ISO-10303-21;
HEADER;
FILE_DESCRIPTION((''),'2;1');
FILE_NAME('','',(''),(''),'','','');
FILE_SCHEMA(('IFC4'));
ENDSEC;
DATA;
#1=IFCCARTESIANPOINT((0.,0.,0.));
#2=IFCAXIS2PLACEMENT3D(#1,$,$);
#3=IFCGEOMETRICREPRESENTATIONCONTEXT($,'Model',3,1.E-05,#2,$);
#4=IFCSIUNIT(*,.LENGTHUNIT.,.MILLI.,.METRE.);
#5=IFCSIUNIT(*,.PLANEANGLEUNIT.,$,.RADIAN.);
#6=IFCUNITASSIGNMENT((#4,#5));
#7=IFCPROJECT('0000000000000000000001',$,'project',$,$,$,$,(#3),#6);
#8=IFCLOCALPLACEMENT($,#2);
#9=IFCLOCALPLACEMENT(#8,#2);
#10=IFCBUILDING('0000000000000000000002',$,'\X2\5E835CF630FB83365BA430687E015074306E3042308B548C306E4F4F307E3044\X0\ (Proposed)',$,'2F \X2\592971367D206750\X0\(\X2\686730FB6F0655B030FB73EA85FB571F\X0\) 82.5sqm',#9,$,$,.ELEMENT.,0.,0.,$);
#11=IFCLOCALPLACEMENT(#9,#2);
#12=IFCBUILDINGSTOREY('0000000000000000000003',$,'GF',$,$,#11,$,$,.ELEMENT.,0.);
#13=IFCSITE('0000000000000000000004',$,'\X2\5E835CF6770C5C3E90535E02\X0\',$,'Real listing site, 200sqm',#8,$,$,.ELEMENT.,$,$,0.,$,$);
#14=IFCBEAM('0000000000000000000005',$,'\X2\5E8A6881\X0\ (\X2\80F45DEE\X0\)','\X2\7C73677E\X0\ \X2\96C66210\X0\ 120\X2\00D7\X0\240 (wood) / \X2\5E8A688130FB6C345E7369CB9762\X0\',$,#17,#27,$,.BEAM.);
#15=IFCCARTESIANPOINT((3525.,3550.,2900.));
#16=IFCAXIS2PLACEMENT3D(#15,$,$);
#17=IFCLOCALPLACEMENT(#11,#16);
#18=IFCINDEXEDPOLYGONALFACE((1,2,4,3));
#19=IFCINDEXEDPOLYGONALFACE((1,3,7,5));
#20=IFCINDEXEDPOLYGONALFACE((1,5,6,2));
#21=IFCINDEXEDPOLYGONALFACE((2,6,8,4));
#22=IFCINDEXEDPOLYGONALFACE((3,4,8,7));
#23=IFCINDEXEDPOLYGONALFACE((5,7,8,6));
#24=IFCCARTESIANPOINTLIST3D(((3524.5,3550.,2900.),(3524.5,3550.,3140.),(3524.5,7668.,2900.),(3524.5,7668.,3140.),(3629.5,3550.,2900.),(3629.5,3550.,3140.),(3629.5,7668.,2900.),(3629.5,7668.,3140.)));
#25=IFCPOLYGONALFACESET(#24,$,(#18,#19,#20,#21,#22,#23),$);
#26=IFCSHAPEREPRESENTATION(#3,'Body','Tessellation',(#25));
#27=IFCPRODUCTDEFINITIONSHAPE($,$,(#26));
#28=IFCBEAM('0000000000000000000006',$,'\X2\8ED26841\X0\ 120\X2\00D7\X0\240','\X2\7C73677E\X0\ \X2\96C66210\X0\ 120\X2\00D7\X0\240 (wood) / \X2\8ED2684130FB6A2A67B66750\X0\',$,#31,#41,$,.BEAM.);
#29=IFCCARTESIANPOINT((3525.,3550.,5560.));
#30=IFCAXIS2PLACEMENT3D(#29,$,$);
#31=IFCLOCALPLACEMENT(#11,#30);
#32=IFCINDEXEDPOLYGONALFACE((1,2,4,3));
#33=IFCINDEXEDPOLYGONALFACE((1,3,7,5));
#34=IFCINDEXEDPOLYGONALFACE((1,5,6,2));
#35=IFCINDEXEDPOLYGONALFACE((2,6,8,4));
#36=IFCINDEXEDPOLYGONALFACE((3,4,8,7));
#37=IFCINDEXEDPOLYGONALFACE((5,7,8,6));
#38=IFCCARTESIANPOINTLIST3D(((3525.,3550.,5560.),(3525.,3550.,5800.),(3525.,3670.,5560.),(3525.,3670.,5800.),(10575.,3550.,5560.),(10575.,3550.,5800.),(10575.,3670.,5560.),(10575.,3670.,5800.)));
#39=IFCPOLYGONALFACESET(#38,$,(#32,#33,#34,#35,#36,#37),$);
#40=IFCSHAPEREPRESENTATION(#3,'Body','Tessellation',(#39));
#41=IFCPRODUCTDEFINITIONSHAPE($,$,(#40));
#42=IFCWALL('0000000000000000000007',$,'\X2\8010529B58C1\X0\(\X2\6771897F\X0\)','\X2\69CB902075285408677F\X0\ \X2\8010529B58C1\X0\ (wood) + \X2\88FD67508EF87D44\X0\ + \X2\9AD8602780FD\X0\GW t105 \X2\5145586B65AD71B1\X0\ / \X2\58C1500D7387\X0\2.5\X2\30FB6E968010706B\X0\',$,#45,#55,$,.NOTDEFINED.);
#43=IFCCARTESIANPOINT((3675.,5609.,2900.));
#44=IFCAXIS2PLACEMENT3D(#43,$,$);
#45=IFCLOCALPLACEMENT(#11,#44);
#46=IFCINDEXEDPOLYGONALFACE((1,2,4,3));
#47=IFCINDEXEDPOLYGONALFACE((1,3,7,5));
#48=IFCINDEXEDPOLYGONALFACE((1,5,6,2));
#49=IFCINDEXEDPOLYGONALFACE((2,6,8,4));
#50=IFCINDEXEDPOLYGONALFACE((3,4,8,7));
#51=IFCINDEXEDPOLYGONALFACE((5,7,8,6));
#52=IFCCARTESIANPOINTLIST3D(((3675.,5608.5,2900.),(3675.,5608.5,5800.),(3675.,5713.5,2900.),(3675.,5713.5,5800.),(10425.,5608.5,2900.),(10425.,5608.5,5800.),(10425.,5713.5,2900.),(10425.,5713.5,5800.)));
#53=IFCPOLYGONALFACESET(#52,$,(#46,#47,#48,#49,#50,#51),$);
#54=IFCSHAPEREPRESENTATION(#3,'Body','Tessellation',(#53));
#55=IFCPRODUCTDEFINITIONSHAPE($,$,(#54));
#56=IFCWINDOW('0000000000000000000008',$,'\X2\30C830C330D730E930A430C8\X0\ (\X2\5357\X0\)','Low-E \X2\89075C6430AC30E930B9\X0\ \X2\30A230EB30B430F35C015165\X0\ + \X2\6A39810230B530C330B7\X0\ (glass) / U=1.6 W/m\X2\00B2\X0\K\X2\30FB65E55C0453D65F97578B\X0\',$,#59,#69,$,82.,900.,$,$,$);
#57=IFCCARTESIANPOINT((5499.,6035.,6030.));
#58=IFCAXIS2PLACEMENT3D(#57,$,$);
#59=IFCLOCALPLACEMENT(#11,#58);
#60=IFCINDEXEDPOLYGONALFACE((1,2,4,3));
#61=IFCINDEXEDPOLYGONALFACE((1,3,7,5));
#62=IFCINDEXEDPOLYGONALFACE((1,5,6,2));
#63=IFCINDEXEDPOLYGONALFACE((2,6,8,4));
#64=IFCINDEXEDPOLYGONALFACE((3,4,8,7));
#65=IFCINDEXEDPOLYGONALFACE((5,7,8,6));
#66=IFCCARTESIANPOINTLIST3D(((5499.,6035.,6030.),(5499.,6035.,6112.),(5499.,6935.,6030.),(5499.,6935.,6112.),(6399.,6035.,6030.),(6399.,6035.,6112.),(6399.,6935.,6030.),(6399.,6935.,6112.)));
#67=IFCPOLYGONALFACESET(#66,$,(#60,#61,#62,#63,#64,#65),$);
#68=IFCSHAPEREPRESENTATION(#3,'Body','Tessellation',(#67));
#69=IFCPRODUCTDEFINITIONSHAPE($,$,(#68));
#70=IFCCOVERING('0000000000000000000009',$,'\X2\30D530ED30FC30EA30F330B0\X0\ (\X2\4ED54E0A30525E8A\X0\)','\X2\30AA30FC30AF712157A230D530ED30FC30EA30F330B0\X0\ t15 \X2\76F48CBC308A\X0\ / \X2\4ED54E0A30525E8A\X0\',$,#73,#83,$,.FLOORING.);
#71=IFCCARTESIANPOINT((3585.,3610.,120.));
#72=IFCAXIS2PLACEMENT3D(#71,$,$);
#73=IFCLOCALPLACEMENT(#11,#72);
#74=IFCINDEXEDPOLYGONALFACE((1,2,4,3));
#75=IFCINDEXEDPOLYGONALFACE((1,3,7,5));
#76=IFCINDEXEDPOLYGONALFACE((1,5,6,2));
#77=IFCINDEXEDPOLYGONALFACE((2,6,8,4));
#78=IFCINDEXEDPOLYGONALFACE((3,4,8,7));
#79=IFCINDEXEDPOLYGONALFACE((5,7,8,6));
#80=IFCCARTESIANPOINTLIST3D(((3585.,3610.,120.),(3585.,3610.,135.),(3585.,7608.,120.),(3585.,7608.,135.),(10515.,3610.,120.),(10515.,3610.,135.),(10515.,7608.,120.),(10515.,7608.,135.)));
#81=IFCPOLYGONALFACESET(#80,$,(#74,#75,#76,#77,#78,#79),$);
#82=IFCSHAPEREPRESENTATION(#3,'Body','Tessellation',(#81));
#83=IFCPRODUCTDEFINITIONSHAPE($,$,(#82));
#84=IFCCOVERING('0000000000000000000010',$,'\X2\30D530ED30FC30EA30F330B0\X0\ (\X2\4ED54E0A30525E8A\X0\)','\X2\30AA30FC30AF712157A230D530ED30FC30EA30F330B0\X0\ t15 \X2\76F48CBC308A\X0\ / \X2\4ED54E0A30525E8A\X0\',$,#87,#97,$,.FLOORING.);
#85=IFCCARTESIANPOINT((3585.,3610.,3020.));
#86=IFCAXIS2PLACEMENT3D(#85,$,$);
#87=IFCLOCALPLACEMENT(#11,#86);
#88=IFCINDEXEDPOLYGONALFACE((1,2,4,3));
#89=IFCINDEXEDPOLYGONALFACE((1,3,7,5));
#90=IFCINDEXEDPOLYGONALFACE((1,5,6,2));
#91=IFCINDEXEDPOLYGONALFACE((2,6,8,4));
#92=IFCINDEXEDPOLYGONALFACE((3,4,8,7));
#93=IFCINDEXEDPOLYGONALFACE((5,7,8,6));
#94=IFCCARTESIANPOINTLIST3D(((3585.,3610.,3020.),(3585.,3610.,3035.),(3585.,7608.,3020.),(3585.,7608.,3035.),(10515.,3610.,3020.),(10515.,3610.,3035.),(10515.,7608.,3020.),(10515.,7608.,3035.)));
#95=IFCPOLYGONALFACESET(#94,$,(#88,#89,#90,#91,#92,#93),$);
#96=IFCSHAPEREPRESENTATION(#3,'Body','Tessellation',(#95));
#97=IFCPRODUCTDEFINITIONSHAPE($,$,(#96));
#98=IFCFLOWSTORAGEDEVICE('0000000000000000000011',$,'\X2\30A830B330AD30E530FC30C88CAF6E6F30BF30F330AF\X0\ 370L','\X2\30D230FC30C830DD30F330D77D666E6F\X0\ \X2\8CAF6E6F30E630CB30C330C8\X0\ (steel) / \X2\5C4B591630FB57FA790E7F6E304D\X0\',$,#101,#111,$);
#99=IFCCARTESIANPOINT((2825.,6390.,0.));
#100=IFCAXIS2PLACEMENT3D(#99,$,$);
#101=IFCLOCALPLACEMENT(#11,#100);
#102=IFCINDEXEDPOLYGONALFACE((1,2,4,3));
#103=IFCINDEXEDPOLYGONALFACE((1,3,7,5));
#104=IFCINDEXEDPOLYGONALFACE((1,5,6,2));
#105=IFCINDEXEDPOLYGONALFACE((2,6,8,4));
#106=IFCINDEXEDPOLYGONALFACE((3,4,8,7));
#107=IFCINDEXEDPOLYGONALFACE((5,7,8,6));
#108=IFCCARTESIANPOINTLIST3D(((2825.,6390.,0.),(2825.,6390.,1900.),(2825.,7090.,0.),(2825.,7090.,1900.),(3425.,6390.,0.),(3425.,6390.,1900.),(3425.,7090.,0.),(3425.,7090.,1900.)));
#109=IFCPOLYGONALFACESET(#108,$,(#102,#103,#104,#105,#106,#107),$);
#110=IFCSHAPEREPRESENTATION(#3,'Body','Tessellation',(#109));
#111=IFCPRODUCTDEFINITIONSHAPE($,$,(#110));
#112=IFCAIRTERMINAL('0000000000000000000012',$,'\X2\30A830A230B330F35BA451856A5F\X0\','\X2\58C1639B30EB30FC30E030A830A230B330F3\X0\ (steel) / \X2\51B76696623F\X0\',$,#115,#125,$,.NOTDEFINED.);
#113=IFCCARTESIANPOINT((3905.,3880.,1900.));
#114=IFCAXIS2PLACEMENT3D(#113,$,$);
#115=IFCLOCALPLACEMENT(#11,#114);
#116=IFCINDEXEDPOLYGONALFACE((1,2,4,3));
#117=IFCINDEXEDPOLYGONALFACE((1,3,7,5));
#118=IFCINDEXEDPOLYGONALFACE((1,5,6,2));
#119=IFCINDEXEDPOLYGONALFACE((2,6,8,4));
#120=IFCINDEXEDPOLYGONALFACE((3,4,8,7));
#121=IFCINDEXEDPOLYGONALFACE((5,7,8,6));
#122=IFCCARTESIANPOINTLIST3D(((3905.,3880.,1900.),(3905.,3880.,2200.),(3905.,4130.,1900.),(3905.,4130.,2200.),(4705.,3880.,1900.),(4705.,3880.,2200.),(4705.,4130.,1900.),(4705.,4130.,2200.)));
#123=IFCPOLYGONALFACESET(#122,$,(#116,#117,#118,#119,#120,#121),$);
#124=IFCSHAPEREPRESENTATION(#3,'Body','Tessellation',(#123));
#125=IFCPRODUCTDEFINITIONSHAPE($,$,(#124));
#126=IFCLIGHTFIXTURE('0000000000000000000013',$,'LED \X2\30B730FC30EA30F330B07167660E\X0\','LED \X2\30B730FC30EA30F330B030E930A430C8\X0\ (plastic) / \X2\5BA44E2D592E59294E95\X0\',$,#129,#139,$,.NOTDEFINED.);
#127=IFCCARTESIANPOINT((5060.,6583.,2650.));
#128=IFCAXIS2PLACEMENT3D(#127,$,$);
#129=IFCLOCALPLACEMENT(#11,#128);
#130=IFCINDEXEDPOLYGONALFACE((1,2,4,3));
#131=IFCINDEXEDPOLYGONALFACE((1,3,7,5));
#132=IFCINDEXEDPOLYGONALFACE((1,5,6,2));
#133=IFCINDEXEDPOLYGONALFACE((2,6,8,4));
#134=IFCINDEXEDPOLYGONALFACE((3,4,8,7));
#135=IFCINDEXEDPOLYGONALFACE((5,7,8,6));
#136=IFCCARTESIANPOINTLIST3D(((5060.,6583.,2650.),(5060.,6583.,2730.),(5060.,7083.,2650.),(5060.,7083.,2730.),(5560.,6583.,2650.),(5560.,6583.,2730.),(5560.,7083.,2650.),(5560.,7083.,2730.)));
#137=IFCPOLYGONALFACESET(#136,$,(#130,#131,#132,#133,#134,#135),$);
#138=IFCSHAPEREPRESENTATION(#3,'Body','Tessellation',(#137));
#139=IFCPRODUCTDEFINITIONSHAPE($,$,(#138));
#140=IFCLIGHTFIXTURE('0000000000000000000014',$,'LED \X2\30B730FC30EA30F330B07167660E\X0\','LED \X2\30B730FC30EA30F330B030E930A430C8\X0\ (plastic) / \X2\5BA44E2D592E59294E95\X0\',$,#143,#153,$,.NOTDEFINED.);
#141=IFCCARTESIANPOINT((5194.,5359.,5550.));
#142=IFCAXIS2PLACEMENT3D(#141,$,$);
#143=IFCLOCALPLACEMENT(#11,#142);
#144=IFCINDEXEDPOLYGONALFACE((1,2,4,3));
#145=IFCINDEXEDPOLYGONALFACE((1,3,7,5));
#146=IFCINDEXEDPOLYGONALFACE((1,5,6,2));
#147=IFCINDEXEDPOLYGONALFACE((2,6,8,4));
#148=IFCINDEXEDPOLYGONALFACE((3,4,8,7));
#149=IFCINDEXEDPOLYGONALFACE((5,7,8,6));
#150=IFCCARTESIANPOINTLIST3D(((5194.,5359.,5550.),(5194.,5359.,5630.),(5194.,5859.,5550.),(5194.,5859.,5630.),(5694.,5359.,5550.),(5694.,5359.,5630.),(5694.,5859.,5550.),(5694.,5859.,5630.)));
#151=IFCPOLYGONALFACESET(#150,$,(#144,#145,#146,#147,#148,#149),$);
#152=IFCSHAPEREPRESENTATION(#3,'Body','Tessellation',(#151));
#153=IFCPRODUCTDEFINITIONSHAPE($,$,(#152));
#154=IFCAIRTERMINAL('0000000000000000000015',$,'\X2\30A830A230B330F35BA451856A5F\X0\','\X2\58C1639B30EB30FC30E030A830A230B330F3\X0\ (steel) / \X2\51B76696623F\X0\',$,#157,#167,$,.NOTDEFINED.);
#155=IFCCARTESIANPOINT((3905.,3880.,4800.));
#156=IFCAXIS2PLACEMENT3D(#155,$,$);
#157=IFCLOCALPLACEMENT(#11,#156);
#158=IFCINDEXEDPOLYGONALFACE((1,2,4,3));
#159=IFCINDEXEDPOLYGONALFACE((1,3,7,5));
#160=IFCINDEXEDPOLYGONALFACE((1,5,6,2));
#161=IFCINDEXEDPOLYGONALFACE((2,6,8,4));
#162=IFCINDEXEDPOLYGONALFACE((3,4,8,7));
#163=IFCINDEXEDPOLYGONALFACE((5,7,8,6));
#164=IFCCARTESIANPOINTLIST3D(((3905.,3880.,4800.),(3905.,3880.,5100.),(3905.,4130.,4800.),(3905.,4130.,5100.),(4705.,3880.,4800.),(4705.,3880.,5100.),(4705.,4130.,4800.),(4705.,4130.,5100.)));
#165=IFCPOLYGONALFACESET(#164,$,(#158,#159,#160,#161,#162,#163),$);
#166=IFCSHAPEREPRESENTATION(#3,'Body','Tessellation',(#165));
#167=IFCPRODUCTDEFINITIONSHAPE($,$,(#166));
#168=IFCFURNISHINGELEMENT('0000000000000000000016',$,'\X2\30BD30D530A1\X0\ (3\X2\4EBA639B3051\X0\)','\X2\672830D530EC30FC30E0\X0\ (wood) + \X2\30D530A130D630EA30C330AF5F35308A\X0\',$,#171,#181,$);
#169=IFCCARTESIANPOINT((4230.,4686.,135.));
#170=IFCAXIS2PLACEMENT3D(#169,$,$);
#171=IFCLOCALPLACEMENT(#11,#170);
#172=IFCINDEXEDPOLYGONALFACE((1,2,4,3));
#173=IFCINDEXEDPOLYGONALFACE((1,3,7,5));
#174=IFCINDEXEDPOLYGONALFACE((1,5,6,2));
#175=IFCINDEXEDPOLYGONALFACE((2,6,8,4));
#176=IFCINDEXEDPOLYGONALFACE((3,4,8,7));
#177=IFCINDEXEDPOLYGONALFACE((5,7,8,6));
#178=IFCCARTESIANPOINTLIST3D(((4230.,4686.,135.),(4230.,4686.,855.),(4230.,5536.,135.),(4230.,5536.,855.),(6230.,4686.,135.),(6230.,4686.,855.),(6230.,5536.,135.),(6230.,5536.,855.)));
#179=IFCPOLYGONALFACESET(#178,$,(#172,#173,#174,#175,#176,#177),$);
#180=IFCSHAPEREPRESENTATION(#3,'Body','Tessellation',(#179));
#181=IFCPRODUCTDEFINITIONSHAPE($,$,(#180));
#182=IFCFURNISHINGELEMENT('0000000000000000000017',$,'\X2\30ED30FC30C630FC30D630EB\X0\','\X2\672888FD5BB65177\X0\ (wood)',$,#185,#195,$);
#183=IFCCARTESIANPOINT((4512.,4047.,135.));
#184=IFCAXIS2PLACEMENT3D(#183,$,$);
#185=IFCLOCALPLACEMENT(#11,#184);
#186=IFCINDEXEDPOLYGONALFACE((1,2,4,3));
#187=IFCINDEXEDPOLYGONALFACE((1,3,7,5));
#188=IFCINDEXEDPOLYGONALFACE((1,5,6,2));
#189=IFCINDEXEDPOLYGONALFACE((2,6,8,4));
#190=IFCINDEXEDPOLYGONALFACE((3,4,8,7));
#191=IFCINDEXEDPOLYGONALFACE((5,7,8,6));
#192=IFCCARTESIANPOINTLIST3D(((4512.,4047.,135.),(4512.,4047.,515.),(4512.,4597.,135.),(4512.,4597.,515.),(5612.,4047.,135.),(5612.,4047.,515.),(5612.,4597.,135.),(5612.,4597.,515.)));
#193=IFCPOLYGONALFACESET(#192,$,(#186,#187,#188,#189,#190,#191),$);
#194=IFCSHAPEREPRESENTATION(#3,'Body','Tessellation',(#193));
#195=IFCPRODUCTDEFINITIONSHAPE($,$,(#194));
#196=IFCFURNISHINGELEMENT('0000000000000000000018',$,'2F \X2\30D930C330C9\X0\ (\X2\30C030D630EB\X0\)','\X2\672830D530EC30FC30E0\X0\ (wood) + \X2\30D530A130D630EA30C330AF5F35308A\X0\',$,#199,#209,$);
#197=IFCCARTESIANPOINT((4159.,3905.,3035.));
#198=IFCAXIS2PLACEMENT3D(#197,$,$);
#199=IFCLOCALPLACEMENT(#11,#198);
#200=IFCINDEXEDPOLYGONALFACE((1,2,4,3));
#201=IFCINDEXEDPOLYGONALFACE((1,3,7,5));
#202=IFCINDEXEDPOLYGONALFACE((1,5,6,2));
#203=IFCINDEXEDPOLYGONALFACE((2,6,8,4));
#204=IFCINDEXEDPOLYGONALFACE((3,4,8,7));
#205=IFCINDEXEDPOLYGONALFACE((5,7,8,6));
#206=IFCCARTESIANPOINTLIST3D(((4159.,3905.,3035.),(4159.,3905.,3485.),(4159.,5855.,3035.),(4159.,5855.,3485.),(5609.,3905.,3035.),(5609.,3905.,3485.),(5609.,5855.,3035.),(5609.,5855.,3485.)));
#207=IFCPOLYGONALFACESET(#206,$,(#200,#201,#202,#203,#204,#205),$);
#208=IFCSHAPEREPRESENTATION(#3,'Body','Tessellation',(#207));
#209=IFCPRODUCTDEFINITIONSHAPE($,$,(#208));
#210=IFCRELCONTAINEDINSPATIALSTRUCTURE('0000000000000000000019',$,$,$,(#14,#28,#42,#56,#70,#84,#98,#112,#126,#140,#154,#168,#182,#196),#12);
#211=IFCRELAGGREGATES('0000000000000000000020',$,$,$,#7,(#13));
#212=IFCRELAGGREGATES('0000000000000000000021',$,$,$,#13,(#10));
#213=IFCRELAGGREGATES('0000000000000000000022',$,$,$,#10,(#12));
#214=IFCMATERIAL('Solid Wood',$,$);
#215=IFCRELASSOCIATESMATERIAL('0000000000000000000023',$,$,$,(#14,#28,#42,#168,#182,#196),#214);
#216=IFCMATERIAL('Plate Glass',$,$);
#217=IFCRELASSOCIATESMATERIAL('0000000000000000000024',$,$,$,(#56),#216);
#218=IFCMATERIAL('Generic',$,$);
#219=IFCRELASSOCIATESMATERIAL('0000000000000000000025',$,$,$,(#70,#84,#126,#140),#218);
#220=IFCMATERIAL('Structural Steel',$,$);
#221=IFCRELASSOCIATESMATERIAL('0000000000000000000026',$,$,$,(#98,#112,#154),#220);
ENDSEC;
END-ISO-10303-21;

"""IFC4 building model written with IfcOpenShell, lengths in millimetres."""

from ifc_helpers import new_model, si_unit, frame, frame_2d, origin, place, context, project, spatial, rectangle, extrude, material, element, save


model = new_model("IFC4")

# Units and contexts
model_context = context("Model", 3, precision=1e-05, world=origin())
ifc_project = project(units=[si_unit("LENGTHUNIT", "METRE", prefix="MILLI"), si_unit("PLANEANGLEUNIT", "RADIAN")], contexts=[model_context])

# Site, building, storey
site_placement = place(None, origin())
site = spatial("IfcSite", under=ifc_project, at=site_placement, Name="広島県尾道市", ObjectType="Real listing site, 200sqm", CompositionType="ELEMENT", RefElevation=0.0)
building_placement = place(site_placement, origin())
building = spatial("IfcBuilding", under=site, at=building_placement, Name="広島・茶室と縁側のある和の住まい (Proposed)", ObjectType="2F 天然素材(桧・漆喰・珪藻土) 82.5sqm", CompositionType="ELEMENT", ElevationOfRefHeight=0.0, ElevationOfTerrain=0.0)
storey_placement = place(building_placement, origin())
storey = spatial("IfcBuildingStorey", under=building, at=storey_placement, Name="GF", CompositionType="ELEMENT", Elevation=0.0)

# Shared definitions
ifc_material_1 = material(Name="Solid Wood")

# Beams
beam_1_placement = place(storey_placement, frame((3525.0, 3550.0, 2900.0)))
element("IfcBeam", 1, at=beam_1_placement, inside=storey, material=ifc_material_1, Name="床梁 (胴差)", Description="米松 集成 120×240 (wood) / 床梁・水平構面", PredefinedType="BEAM", context=model_context, shape_type="SweptSolid", body=[
    extrude(rectangle(XDim=105.0, YDim=4118.0, at=frame_2d((52.0, 2059.0))), frame((3525.0, 3550.0, 2900.0)), (0.0, 0.0, 1.0), 240.0),
])
beam_2_placement = place(storey_placement, frame((3525.0, 3550.0, 5560.0)))
element("IfcBeam", 2, at=beam_2_placement, inside=storey, material=ifc_material_1, Name="軒桁 120×240", Description="米松 集成 120×240 (wood) / 軒桁・横架材", PredefinedType="BEAM", context=model_context, shape_type="SweptSolid", body=[
    extrude(rectangle(XDim=7050.0, YDim=120.0, at=frame_2d((3525.0, 60.0))), frame((3525.0, 3550.0, 5560.0)), (0.0, 0.0, 1.0), 240.0),
])

# Wall
wall_1_placement = place(storey_placement, frame((3675.0, 5609.0, 2900.0)))
element("IfcWall", 3, at=wall_1_placement, inside=storey, material=ifc_material_1, Name="耐力壁(東西)", Description="構造用合板 耐力壁 (wood) + 製材軸組 + 高性能GW t105 充填断熱 / 壁倍率2.5・準耐火", PredefinedType="NOTDEFINED", context=model_context, shape_type="SweptSolid", body=[
    extrude(rectangle(XDim=6750.0, YDim=105.0, at=frame_2d((3375.0, 52.0))), frame((3675.0, 5609.0, 2900.0)), (0.0, 0.0, 1.0), 2900.0),
])

# Window
ifc_material_2 = material(Name="Plate Glass")
window_placement = place(storey_placement, frame((5499.0, 6035.0, 6030.0)))
element("IfcWindow", 4, at=window_placement, inside=storey, material=ifc_material_2, Name="トップライト (南)", Description="Low-E 複層ガラス アルゴン封入 + 樹脂サッシ (glass) / U=1.6 W/m²K・日射取得型", OverallHeight=82.0, OverallWidth=900.0, context=model_context, shape_type="SweptSolid", body=[
    extrude(rectangle(XDim=900.0, YDim=900.0, at=frame_2d((450.0, 450.0))), frame((5499.0, 6035.0, 6030.0)), (0.0, 0.0, 1.0), 82.0),
])

# Coverings
ifc_material_3 = material(Name="Generic")
covering_1_placement = place(storey_placement, frame((3585.0, 3610.0, 120.0)))
element("IfcCovering", 5, at=covering_1_placement, inside=storey, material=ifc_material_3, Name="フローリング (仕上げ床)", Description="オーク無垢フローリング t15 直貼り / 仕上げ床", PredefinedType="FLOORING", context=model_context, shape_type="SweptSolid", body=[
    extrude(rectangle(XDim=6930.0, YDim=3998.0, at=frame_2d((3465.0, 1999.0))), frame((3585.0, 3610.0, 120.0)), (0.0, 0.0, 1.0), 15.0),
])
covering_2_placement = place(storey_placement, frame((3585.0, 3610.0, 3020.0)))
element("IfcCovering", 6, at=covering_2_placement, inside=storey, material=ifc_material_3, Name="フローリング (仕上げ床)", Description="オーク無垢フローリング t15 直貼り / 仕上げ床", PredefinedType="FLOORING", context=model_context, shape_type="SweptSolid", body=[
    extrude(rectangle(XDim=6930.0, YDim=3998.0, at=frame_2d((3465.0, 1999.0))), frame((3585.0, 3610.0, 3020.0)), (0.0, 0.0, 1.0), 15.0),
])

# Flow storage device
ifc_material_4 = material(Name="Structural Steel")
flow_storage_device_placement = place(storey_placement, frame((2825.0, 6390.0, 0.0)))
element("IfcFlowStorageDevice", 7, at=flow_storage_device_placement, inside=storey, material=ifc_material_4, Name="エコキュート貯湯タンク 370L", Description="ヒートポンプ給湯 貯湯ユニット (steel) / 屋外・基礎置き", context=model_context, shape_type="SweptSolid", body=[
    extrude(rectangle(XDim=600.0, YDim=700.0, at=frame_2d((300.0, 350.0))), frame((2825.0, 6390.0, 0.0)), (0.0, 0.0, 1.0), 1900.0),
])

# Air terminal
air_terminal_1_placement = place(storey_placement, frame((3905.0, 3880.0, 1900.0)))
element("IfcAirTerminal", 8, at=air_terminal_1_placement, inside=storey, material=ifc_material_4, Name="エアコン室内機", Description="壁掛ルームエアコン (steel) / 冷暖房", PredefinedType="NOTDEFINED", context=model_context, shape_type="SweptSolid", body=[
    extrude(rectangle(XDim=800.0, YDim=250.0, at=frame_2d((400.0, 125.0))), frame((3905.0, 3880.0, 1900.0)), (0.0, 0.0, 1.0), 300.0),
])

# Light fixtures
light_fixture_1_placement = place(storey_placement, frame((5060.0, 6583.0, 2650.0)))
element("IfcLightFixture", 9, at=light_fixture_1_placement, inside=storey, material=ifc_material_3, Name="LED シーリング照明", Description="LED シーリングライト (plastic) / 室中央天井", PredefinedType="NOTDEFINED", context=model_context, shape_type="SweptSolid", body=[
    extrude(rectangle(XDim=500.0, YDim=500.0, at=frame_2d((250.0, 250.0))), frame((5060.0, 6583.0, 2650.0)), (0.0, 0.0, 1.0), 80.0),
])
light_fixture_2_placement = place(storey_placement, frame((5194.0, 5359.0, 5550.0)))
element("IfcLightFixture", 10, at=light_fixture_2_placement, inside=storey, material=ifc_material_3, Name="LED シーリング照明", Description="LED シーリングライト (plastic) / 室中央天井", PredefinedType="NOTDEFINED", context=model_context, shape_type="SweptSolid", body=[
    extrude(rectangle(XDim=500.0, YDim=500.0, at=frame_2d((250.0, 250.0))), frame((5194.0, 5359.0, 5550.0)), (0.0, 0.0, 1.0), 80.0),
])

# Air terminal
air_terminal_2_placement = place(storey_placement, frame((3905.0, 3880.0, 4800.0)))
element("IfcAirTerminal", 11, at=air_terminal_2_placement, inside=storey, material=ifc_material_4, Name="エアコン室内機", Description="壁掛ルームエアコン (steel) / 冷暖房", PredefinedType="NOTDEFINED", context=model_context, shape_type="SweptSolid", body=[
    extrude(rectangle(XDim=800.0, YDim=250.0, at=frame_2d((400.0, 125.0))), frame((3905.0, 3880.0, 4800.0)), (0.0, 0.0, 1.0), 300.0),
])

# Furnishing elements
furnishing_1_placement = place(storey_placement, frame((4230.0, 4686.0, 135.0)))
element("IfcFurnishingElement", 12, at=furnishing_1_placement, inside=storey, material=ifc_material_1, Name="ソファ (3人掛け)", Description="木フレーム (wood) + ファブリック張り", context=model_context, shape_type="SweptSolid", body=[
    extrude(rectangle(XDim=2000.0, YDim=850.0, at=frame_2d((1000.0, 425.0))), frame((4230.0, 4686.0, 135.0)), (0.0, 0.0, 1.0), 720.0),
])
furnishing_2_placement = place(storey_placement, frame((4512.0, 4047.0, 135.0)))
element("IfcFurnishingElement", 13, at=furnishing_2_placement, inside=storey, material=ifc_material_1, Name="ローテーブル", Description="木製家具 (wood)", context=model_context, shape_type="SweptSolid", body=[
    extrude(rectangle(XDim=1100.0, YDim=550.0, at=frame_2d((550.0, 275.0))), frame((4512.0, 4047.0, 135.0)), (0.0, 0.0, 1.0), 380.0),
])
furnishing_3_placement = place(storey_placement, frame((4159.0, 3905.0, 3035.0)))
element("IfcFurnishingElement", 14, at=furnishing_3_placement, inside=storey, material=ifc_material_1, Name="2F ベッド (ダブル)", Description="木フレーム (wood) + ファブリック張り", context=model_context, shape_type="SweptSolid", body=[
    extrude(rectangle(XDim=1450.0, YDim=1950.0, at=frame_2d((725.0, 975.0))), frame((4159.0, 3905.0, 3035.0)), (0.0, 0.0, 1.0), 450.0),
])

save(model, "model.ifc")
